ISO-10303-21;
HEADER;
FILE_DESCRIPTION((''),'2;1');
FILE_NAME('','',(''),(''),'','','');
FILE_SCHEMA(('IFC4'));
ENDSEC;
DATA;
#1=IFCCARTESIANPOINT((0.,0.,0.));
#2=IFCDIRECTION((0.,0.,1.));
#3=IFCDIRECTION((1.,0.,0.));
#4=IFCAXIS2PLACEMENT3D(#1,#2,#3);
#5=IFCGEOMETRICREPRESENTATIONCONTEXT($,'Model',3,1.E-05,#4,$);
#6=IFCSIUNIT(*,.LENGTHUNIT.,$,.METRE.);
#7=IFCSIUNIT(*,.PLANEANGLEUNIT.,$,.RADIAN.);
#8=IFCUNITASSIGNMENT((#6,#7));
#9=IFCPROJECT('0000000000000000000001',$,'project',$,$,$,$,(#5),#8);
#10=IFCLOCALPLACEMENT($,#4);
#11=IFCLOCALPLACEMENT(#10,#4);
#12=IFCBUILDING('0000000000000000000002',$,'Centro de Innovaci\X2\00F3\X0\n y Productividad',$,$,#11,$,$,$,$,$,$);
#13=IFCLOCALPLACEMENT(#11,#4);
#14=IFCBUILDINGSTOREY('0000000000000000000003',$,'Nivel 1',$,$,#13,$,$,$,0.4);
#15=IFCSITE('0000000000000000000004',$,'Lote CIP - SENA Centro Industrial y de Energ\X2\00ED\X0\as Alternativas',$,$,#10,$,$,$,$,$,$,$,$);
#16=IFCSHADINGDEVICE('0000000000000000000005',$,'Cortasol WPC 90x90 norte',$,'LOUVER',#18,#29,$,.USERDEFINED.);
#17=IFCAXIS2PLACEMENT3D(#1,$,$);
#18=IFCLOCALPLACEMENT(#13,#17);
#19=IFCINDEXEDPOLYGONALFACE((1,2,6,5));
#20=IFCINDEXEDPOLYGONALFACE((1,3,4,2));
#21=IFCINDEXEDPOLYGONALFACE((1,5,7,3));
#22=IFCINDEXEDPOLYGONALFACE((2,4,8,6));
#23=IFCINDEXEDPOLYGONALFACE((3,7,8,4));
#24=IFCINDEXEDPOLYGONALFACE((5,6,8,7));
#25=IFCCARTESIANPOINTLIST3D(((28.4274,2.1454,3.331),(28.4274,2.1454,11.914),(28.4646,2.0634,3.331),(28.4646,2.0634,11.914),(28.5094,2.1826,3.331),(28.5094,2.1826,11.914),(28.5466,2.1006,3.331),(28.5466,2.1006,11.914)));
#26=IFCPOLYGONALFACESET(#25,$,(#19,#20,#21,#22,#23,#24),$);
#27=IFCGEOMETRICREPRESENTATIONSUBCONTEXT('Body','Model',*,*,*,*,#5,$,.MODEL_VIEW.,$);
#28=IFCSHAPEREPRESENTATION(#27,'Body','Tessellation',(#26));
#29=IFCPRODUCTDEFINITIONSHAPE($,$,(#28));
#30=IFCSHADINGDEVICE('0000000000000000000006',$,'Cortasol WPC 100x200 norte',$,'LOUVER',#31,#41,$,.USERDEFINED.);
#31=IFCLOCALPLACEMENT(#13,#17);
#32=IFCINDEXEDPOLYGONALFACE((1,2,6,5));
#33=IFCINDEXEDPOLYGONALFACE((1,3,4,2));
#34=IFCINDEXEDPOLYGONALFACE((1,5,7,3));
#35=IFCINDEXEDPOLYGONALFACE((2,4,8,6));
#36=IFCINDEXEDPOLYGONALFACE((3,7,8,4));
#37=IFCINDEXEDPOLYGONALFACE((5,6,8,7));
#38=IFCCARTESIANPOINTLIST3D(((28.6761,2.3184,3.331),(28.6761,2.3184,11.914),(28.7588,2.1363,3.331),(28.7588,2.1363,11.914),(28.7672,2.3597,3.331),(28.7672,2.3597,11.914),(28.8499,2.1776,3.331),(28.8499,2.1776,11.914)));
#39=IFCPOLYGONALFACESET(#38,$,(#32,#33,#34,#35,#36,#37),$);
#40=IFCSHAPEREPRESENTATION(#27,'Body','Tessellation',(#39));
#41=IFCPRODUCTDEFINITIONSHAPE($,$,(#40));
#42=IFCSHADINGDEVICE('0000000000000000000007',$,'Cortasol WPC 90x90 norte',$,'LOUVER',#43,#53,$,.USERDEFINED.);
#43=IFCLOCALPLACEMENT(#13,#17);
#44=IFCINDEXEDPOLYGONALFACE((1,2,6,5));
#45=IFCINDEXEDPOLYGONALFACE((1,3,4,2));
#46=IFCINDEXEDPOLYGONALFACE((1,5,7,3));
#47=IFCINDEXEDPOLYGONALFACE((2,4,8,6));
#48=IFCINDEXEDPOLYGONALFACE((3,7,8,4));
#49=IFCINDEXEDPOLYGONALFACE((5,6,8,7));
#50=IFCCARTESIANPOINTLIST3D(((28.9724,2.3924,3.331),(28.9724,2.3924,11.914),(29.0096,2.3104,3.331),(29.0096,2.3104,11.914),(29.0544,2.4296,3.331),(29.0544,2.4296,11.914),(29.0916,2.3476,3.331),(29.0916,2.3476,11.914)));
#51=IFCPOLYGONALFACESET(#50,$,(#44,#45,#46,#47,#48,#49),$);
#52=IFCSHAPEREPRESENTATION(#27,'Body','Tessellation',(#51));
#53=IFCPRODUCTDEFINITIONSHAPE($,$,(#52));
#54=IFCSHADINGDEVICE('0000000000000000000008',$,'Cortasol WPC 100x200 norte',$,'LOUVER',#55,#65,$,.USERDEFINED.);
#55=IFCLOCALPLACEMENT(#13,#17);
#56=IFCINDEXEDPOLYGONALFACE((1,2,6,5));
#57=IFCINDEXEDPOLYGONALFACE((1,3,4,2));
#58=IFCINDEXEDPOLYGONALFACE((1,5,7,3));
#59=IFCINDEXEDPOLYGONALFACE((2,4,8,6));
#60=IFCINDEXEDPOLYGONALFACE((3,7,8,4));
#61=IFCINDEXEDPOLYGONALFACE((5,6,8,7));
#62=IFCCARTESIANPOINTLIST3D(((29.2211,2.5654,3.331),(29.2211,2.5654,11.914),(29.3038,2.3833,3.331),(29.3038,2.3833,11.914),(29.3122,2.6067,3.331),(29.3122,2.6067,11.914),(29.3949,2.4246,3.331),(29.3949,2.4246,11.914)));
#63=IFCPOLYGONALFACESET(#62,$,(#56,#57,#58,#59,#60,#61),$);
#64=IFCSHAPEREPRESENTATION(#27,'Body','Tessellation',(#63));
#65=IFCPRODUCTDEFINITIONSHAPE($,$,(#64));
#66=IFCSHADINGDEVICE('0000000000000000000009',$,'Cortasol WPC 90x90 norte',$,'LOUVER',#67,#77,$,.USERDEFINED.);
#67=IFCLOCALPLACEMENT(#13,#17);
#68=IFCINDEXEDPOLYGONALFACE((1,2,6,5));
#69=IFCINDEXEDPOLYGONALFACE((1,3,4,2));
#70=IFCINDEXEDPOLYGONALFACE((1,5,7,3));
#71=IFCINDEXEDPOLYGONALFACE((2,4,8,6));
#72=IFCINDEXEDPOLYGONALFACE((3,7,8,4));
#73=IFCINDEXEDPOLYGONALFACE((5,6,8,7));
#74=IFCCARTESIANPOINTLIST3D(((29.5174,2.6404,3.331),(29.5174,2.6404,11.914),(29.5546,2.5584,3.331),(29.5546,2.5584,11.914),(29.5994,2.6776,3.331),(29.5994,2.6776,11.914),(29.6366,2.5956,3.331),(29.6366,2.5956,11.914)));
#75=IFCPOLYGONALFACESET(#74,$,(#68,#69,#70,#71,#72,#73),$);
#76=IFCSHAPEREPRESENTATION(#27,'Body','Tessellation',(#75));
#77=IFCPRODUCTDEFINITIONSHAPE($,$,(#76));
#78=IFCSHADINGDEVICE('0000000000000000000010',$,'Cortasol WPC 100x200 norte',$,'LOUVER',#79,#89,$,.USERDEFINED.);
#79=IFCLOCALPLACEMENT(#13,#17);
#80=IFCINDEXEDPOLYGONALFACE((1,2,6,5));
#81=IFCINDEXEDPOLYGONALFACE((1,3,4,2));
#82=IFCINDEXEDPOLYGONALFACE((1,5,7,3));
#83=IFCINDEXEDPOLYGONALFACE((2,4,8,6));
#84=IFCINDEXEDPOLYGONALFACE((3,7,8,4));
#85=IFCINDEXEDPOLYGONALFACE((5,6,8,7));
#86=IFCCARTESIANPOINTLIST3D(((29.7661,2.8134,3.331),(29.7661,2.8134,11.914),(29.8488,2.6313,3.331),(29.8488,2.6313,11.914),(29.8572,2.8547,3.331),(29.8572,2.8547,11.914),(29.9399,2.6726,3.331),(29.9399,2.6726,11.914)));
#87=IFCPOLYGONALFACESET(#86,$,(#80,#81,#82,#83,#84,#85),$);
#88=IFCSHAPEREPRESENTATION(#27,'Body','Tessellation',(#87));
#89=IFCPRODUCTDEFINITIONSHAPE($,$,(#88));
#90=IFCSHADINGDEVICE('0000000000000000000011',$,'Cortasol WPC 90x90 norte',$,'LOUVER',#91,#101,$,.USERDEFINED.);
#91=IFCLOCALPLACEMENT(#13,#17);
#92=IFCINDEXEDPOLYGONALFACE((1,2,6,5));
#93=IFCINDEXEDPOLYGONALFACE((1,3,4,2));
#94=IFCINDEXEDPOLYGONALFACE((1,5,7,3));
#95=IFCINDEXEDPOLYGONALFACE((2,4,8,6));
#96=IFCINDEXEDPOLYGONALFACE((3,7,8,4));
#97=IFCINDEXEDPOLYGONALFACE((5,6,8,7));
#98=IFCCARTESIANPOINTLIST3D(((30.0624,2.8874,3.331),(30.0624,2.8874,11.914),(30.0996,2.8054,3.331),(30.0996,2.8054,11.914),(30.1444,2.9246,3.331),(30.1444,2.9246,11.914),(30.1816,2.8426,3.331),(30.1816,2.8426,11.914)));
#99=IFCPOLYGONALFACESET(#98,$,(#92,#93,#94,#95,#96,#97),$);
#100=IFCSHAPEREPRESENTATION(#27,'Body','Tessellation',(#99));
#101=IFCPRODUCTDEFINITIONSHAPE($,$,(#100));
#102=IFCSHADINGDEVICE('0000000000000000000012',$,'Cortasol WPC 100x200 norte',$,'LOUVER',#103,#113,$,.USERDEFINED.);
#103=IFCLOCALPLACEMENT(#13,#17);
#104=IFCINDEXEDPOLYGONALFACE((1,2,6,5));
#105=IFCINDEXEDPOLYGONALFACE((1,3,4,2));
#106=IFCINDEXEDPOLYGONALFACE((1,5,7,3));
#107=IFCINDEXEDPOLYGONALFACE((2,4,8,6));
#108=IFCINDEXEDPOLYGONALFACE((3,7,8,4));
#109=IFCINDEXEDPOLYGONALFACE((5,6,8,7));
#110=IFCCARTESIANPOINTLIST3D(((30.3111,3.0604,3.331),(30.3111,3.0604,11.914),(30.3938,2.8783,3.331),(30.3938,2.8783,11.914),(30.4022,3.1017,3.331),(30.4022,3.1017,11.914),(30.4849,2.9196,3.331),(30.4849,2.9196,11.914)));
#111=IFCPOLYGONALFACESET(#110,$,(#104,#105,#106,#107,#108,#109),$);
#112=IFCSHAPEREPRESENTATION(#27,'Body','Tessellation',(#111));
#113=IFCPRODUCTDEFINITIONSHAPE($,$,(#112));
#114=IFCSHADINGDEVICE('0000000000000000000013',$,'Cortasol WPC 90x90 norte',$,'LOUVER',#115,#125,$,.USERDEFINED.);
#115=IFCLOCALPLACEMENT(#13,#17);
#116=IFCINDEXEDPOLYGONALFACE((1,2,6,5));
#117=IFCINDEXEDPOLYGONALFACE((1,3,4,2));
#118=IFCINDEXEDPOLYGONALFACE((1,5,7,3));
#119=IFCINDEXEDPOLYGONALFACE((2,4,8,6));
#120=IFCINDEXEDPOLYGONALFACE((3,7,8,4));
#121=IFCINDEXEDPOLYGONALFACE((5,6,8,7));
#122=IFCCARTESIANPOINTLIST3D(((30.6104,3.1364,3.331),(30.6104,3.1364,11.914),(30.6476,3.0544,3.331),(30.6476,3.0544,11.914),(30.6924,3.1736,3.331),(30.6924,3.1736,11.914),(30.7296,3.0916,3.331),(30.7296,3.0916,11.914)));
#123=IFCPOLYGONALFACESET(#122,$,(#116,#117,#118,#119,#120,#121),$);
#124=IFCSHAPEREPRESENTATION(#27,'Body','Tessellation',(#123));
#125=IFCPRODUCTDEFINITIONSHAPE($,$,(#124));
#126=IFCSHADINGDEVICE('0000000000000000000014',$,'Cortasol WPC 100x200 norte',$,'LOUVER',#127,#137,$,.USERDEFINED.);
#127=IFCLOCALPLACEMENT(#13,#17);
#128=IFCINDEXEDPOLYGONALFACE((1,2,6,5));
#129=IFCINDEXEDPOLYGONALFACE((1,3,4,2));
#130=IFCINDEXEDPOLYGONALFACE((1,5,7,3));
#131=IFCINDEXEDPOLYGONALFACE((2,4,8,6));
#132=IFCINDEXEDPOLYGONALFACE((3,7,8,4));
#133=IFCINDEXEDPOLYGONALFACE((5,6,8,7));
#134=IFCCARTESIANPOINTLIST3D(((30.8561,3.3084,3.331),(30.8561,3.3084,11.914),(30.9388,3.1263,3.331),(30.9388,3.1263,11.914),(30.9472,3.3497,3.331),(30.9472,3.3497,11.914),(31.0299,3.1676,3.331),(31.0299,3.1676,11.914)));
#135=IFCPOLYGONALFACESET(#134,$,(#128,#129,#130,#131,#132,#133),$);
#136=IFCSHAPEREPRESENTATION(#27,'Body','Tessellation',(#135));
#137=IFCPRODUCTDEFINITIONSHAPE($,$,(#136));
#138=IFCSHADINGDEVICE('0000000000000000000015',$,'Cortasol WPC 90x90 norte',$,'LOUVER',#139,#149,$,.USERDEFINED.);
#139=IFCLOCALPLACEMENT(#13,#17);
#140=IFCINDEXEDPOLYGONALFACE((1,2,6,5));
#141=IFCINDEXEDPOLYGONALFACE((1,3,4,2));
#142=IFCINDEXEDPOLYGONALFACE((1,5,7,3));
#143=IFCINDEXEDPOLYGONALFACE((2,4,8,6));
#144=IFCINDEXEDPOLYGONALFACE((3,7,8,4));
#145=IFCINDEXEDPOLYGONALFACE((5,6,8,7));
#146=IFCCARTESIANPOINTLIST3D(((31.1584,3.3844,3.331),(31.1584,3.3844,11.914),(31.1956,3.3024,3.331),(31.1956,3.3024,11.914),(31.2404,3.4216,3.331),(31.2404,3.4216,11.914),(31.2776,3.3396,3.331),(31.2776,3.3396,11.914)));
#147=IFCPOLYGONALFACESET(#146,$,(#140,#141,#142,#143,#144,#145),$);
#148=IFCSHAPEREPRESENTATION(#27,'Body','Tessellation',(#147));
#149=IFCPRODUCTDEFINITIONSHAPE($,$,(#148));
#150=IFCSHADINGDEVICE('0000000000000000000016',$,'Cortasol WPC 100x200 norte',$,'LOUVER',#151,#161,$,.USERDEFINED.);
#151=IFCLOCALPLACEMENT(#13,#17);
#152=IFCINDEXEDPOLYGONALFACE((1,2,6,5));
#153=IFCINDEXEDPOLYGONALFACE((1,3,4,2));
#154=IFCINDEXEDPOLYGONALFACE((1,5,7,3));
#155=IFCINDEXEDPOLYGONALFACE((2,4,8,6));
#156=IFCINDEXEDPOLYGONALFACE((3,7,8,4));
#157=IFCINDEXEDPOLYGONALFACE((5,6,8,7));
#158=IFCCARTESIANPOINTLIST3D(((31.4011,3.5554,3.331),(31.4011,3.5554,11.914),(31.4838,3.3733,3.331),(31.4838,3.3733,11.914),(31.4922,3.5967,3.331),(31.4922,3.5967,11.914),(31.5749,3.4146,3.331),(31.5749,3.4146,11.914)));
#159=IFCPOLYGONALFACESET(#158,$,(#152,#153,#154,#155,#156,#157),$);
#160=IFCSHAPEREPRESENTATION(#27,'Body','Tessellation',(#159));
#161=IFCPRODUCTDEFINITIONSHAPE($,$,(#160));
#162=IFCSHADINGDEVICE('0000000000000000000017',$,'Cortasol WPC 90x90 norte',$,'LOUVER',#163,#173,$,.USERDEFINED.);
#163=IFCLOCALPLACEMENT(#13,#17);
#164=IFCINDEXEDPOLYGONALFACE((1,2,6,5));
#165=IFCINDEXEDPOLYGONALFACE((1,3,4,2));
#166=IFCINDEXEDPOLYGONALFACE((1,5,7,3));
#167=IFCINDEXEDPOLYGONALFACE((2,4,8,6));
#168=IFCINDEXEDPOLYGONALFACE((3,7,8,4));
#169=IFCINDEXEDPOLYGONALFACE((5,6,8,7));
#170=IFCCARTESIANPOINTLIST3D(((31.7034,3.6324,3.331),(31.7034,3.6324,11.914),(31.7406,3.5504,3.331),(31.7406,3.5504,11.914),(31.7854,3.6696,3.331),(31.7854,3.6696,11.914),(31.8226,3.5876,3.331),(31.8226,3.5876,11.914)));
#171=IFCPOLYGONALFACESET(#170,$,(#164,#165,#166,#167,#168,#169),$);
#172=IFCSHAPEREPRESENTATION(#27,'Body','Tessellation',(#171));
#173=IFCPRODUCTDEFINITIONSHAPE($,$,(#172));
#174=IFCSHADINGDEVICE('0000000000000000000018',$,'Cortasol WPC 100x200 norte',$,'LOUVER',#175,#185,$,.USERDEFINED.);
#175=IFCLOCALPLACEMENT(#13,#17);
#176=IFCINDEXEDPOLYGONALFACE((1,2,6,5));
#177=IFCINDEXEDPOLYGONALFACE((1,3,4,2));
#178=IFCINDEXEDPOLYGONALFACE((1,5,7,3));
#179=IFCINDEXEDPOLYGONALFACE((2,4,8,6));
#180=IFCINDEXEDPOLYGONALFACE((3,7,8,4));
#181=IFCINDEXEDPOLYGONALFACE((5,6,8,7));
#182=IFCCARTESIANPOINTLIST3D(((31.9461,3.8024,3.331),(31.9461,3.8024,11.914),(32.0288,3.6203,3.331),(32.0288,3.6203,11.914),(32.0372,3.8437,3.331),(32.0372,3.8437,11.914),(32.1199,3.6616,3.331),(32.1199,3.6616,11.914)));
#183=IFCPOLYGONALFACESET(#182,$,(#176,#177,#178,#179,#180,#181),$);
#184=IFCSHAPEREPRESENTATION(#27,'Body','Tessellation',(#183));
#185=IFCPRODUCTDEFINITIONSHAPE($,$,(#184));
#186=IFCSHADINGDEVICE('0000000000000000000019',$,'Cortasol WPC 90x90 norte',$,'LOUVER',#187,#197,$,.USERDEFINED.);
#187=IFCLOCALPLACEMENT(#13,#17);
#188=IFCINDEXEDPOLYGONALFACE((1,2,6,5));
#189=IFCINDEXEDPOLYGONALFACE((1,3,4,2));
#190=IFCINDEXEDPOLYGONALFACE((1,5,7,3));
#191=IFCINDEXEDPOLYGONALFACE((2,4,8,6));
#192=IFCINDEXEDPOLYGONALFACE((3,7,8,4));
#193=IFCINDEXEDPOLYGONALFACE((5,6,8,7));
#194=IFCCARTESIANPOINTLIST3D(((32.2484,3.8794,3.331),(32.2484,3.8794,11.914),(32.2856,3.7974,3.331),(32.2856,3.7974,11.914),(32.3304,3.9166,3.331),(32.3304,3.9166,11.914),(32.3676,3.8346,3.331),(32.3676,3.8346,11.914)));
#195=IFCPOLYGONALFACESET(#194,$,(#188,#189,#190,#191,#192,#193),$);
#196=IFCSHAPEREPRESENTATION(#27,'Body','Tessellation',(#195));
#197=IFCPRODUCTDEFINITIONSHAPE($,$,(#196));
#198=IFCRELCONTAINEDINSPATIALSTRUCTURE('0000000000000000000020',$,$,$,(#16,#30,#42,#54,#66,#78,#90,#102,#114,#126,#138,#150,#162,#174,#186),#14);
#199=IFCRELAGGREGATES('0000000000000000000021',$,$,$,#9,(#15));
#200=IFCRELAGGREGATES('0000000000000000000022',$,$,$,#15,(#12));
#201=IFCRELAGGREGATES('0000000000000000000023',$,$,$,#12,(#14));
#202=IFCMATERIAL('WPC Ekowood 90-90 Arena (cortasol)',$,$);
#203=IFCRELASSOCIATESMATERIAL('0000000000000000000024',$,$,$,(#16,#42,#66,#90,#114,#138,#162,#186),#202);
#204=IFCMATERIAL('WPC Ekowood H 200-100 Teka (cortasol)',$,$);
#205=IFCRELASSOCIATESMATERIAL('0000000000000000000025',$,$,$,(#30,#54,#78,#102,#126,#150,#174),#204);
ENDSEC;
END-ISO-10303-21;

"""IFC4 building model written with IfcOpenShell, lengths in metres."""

from ifc_helpers import new_model, si_unit, frame, origin_with_axes, place, context, subcontext, project, spatial, polyline, outline, extrude, material, element, save


model = new_model("IFC4")

# Units and contexts
model_context = context("Model", 3, precision=1e-05, world=origin_with_axes())
body_context = subcontext(model_context, "Body", "Model", "MODEL_VIEW")
ifc_project = project(units=[si_unit("LENGTHUNIT", "METRE"), si_unit("PLANEANGLEUNIT", "RADIAN")], contexts=[model_context])

# Site, building, storey
site_placement = place(None, origin_with_axes())
site = spatial("IfcSite", under=ifc_project, at=site_placement, Name="Lote CIP - SENA Centro Industrial y de Energías Alternativas")
building_placement = place(site_placement, origin_with_axes())
building = spatial("IfcBuilding", under=site, at=building_placement, Name="Centro de Innovación y Productividad")
storey_placement = place(building_placement, origin_with_axes())
storey = spatial("IfcBuildingStorey", under=building, at=storey_placement, Name="Nivel 1", Elevation=0.4)

# Shading devices
ifc_material_1 = material(Name="WPC Ekowood 90-90 Arena (cortasol)")
shading_device_1_placement = place(storey_placement, origin_with_axes())
element("IfcShadingDevice", 1, at=shading_device_1_placement, inside=storey, material=ifc_material_1, Name="Cortasol WPC 90x90 norte", ObjectType="LOUVER", PredefinedType="USERDEFINED", context=body_context, shape_type="SweptSolid", body=[
    extrude(outline(polyline([(28.4646, 2.0634), (28.4274, 2.1454), (28.5094, 2.1826), (28.5466, 2.1006), (28.4646, 2.0634)])), frame((0.0, 0.0, 3.331)), (0.0, 0.0, 1.0), 8.583),
])
ifc_material_2 = material(Name="WPC Ekowood H 200-100 Teka (cortasol)")
shading_device_2_placement = place(storey_placement, origin_with_axes())
element("IfcShadingDevice", 2, at=shading_device_2_placement, inside=storey, material=ifc_material_2, Name="Cortasol WPC 100x200 norte", ObjectType="LOUVER", PredefinedType="USERDEFINED", context=body_context, shape_type="SweptSolid", body=[
    extrude(outline(polyline([(28.7588, 2.1363), (28.6761, 2.3184), (28.7672, 2.3597), (28.8499, 2.1776), (28.7588, 2.1363)])), frame((0.0, 0.0, 3.331)), (0.0, 0.0, 1.0), 8.583),
])
shading_device_3_placement = place(storey_placement, origin_with_axes())
element("IfcShadingDevice", 3, at=shading_device_3_placement, inside=storey, material=ifc_material_1, Name="Cortasol WPC 90x90 norte", ObjectType="LOUVER", PredefinedType="USERDEFINED", context=body_context, shape_type="SweptSolid", body=[
    extrude(outline(polyline([(29.0096, 2.3104), (28.9724, 2.3924), (29.0544, 2.4296), (29.0916, 2.3476), (29.0096, 2.3104)])), frame((0.0, 0.0, 3.331)), (0.0, 0.0, 1.0), 8.583),
])
shading_device_4_placement = place(storey_placement, origin_with_axes())
element("IfcShadingDevice", 4, at=shading_device_4_placement, inside=storey, material=ifc_material_2, Name="Cortasol WPC 100x200 norte", ObjectType="LOUVER", PredefinedType="USERDEFINED", context=body_context, shape_type="SweptSolid", body=[
    extrude(outline(polyline([(29.3038, 2.3833), (29.2211, 2.5654), (29.3122, 2.6067), (29.3949, 2.4246), (29.3038, 2.3833)])), frame((0.0, 0.0, 3.331)), (0.0, 0.0, 1.0), 8.583),
])
shading_device_5_placement = place(storey_placement, origin_with_axes())
element("IfcShadingDevice", 5, at=shading_device_5_placement, inside=storey, material=ifc_material_1, Name="Cortasol WPC 90x90 norte", ObjectType="LOUVER", PredefinedType="USERDEFINED", context=body_context, shape_type="SweptSolid", body=[
    extrude(outline(polyline([(29.5546, 2.5584), (29.5174, 2.6404), (29.5994, 2.6776), (29.6366, 2.5956), (29.5546, 2.5584)])), frame((0.0, 0.0, 3.331)), (0.0, 0.0, 1.0), 8.583),
])
shading_device_6_placement = place(storey_placement, origin_with_axes())
element("IfcShadingDevice", 6, at=shading_device_6_placement, inside=storey, material=ifc_material_2, Name="Cortasol WPC 100x200 norte", ObjectType="LOUVER", PredefinedType="USERDEFINED", context=body_context, shape_type="SweptSolid", body=[
    extrude(outline(polyline([(29.8488, 2.6313), (29.7661, 2.8134), (29.8572, 2.8547), (29.9399, 2.6726), (29.8488, 2.6313)])), frame((0.0, 0.0, 3.331)), (0.0, 0.0, 1.0), 8.583),
])
shading_device_7_placement = place(storey_placement, origin_with_axes())
element("IfcShadingDevice", 7, at=shading_device_7_placement, inside=storey, material=ifc_material_1, Name="Cortasol WPC 90x90 norte", ObjectType="LOUVER", PredefinedType="USERDEFINED", context=body_context, shape_type="SweptSolid", body=[
    extrude(outline(polyline([(30.0996, 2.8054), (30.0624, 2.8874), (30.1444, 2.9246), (30.1816, 2.8426), (30.0996, 2.8054)])), frame((0.0, 0.0, 3.331)), (0.0, 0.0, 1.0), 8.583),
])
shading_device_8_placement = place(storey_placement, origin_with_axes())
element("IfcShadingDevice", 8, at=shading_device_8_placement, inside=storey, material=ifc_material_2, Name="Cortasol WPC 100x200 norte", ObjectType="LOUVER", PredefinedType="USERDEFINED", context=body_context, shape_type="SweptSolid", body=[
    extrude(outline(polyline([(30.3938, 2.8783), (30.3111, 3.0604), (30.4022, 3.1017), (30.4849, 2.9196), (30.3938, 2.8783)])), frame((0.0, 0.0, 3.331)), (0.0, 0.0, 1.0), 8.583),
])
shading_device_9_placement = place(storey_placement, origin_with_axes())
element("IfcShadingDevice", 9, at=shading_device_9_placement, inside=storey, material=ifc_material_1, Name="Cortasol WPC 90x90 norte", ObjectType="LOUVER", PredefinedType="USERDEFINED", context=body_context, shape_type="SweptSolid", body=[
    extrude(outline(polyline([(30.6476, 3.0544), (30.6104, 3.1364), (30.6924, 3.1736), (30.7296, 3.0916), (30.6476, 3.0544)])), frame((0.0, 0.0, 3.331)), (0.0, 0.0, 1.0), 8.583),
])
shading_device_10_placement = place(storey_placement, origin_with_axes())
element("IfcShadingDevice", 10, at=shading_device_10_placement, inside=storey, material=ifc_material_2, Name="Cortasol WPC 100x200 norte", ObjectType="LOUVER", PredefinedType="USERDEFINED", context=body_context, shape_type="SweptSolid", body=[
    extrude(outline(polyline([(30.9388, 3.1263), (30.8561, 3.3084), (30.9472, 3.3497), (31.0299, 3.1676), (30.9388, 3.1263)])), frame((0.0, 0.0, 3.331)), (0.0, 0.0, 1.0), 8.583),
])
shading_device_11_placement = place(storey_placement, origin_with_axes())
element("IfcShadingDevice", 11, at=shading_device_11_placement, inside=storey, material=ifc_material_1, Name="Cortasol WPC 90x90 norte", ObjectType="LOUVER", PredefinedType="USERDEFINED", context=body_context, shape_type="SweptSolid", body=[
    extrude(outline(polyline([(31.1956, 3.3024), (31.1584, 3.3844), (31.2404, 3.4216), (31.2776, 3.3396), (31.1956, 3.3024)])), frame((0.0, 0.0, 3.331)), (0.0, 0.0, 1.0), 8.583),
])
shading_device_12_placement = place(storey_placement, origin_with_axes())
element("IfcShadingDevice", 12, at=shading_device_12_placement, inside=storey, material=ifc_material_2, Name="Cortasol WPC 100x200 norte", ObjectType="LOUVER", PredefinedType="USERDEFINED", context=body_context, shape_type="SweptSolid", body=[
    extrude(outline(polyline([(31.4838, 3.3733), (31.4011, 3.5554), (31.4922, 3.5967), (31.5749, 3.4146), (31.4838, 3.3733)])), frame((0.0, 0.0, 3.331)), (0.0, 0.0, 1.0), 8.583),
])
shading_device_13_placement = place(storey_placement, origin_with_axes())
element("IfcShadingDevice", 13, at=shading_device_13_placement, inside=storey, material=ifc_material_1, Name="Cortasol WPC 90x90 norte", ObjectType="LOUVER", PredefinedType="USERDEFINED", context=body_context, shape_type="SweptSolid", body=[
    extrude(outline(polyline([(31.7406, 3.5504), (31.7034, 3.6324), (31.7854, 3.6696), (31.8226, 3.5876), (31.7406, 3.5504)])), frame((0.0, 0.0, 3.331)), (0.0, 0.0, 1.0), 8.583),
])
shading_device_14_placement = place(storey_placement, origin_with_axes())
element("IfcShadingDevice", 14, at=shading_device_14_placement, inside=storey, material=ifc_material_2, Name="Cortasol WPC 100x200 norte", ObjectType="LOUVER", PredefinedType="USERDEFINED", context=body_context, shape_type="SweptSolid", body=[
    extrude(outline(polyline([(32.0288, 3.6203), (31.9461, 3.8024), (32.0372, 3.8437), (32.1199, 3.6616), (32.0288, 3.6203)])), frame((0.0, 0.0, 3.331)), (0.0, 0.0, 1.0), 8.583),
])
shading_device_15_placement = place(storey_placement, origin_with_axes())
element("IfcShadingDevice", 15, at=shading_device_15_placement, inside=storey, material=ifc_material_1, Name="Cortasol WPC 90x90 norte", ObjectType="LOUVER", PredefinedType="USERDEFINED", context=body_context, shape_type="SweptSolid", body=[
    extrude(outline(polyline([(32.2856, 3.7974), (32.2484, 3.8794), (32.3304, 3.9166), (32.3676, 3.8346), (32.2856, 3.7974)])), frame((0.0, 0.0, 3.331)), (0.0, 0.0, 1.0), 8.583),
])

save(model, "model.ifc")
